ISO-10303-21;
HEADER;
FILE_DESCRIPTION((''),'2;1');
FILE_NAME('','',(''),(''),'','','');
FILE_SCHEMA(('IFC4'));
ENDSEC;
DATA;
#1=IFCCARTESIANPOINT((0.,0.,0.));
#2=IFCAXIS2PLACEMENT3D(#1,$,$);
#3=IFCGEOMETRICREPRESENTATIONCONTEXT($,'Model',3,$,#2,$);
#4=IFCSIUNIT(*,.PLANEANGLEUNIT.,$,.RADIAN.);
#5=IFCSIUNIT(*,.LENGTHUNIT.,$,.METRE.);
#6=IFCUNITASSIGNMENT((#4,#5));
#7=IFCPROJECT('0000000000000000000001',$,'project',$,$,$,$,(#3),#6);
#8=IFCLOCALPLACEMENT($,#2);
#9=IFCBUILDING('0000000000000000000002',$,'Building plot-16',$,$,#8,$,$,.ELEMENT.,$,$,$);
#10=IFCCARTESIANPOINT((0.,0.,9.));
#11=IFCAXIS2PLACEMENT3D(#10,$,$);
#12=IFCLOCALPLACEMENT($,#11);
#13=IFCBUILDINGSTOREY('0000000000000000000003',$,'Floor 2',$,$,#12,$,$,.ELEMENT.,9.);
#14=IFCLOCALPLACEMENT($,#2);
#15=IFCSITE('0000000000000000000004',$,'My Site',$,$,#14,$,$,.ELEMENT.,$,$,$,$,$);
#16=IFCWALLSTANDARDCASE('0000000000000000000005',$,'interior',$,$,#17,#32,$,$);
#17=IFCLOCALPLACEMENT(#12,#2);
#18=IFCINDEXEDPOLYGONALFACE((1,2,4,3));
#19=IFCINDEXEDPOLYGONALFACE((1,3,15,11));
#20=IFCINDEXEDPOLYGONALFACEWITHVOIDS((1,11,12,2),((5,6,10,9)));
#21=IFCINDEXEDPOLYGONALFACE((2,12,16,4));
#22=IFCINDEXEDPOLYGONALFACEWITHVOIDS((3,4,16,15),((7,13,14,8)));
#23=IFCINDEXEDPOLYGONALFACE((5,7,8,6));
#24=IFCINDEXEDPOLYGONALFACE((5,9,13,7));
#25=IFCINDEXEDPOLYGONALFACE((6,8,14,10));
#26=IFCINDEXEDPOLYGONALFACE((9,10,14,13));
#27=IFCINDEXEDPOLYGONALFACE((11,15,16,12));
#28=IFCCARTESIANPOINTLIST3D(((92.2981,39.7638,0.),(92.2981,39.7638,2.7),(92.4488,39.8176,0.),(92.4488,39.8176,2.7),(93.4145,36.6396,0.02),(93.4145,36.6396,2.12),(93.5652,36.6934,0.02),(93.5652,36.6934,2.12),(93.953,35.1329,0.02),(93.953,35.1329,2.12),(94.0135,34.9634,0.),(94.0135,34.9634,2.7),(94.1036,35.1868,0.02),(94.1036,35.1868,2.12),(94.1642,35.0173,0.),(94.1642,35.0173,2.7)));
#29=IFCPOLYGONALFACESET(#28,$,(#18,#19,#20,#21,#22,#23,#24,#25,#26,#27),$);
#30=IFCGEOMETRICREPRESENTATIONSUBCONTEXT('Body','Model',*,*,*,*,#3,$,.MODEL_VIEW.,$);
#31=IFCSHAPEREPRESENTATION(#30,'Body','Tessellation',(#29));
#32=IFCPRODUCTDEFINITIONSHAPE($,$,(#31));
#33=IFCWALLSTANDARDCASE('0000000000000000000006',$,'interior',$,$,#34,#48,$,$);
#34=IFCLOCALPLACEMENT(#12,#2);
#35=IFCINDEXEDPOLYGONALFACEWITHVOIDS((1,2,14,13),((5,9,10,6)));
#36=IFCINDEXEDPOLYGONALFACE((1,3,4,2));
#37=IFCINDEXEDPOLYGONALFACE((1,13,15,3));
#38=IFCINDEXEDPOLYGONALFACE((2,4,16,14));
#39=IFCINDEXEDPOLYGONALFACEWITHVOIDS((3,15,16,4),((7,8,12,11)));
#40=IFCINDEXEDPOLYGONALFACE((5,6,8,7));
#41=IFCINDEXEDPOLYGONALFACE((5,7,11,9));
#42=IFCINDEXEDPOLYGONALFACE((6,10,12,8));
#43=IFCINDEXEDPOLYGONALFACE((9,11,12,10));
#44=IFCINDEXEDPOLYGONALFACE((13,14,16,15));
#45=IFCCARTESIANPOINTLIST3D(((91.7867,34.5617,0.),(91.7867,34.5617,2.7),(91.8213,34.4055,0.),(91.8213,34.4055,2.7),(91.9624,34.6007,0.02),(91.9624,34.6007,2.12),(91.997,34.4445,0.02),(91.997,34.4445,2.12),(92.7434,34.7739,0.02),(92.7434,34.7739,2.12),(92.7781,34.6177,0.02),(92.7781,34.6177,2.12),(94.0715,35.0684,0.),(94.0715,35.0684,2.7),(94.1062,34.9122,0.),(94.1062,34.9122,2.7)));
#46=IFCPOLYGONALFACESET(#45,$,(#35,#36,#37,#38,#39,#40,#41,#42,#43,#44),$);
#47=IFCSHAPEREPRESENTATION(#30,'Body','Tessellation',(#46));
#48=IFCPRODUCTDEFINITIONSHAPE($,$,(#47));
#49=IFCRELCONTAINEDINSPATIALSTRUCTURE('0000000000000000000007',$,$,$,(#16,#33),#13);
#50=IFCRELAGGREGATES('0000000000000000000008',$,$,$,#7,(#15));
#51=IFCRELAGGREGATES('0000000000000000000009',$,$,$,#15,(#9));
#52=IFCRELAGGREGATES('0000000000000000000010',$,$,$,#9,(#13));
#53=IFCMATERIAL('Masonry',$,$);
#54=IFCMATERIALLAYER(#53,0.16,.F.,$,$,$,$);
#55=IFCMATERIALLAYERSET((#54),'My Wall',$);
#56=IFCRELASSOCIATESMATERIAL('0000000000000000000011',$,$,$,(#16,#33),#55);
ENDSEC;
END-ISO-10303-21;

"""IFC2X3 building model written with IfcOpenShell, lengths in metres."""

from ifc_helpers import new_model, si_unit, frame, origin, place, context, subcontext, project, spatial, polyline, outline, extrude, material, layer, layer_set, layer_usage, element, save


model = new_model("IFC2X3")

# Units and contexts
model_context = context("Model", 3, world=origin())
body_context = subcontext(model_context, "Body", "Model", "MODEL_VIEW")
ifc_project = project(units=[si_unit("PLANEANGLEUNIT", "RADIAN"), si_unit("LENGTHUNIT", "METRE")], contexts=[model_context])

# Site, building, storey
site_placement = place(None, origin())
site = spatial("IfcSite", under=ifc_project, at=site_placement, Name="My Site", CompositionType="ELEMENT")
building_placement = place(None, origin())
building = spatial("IfcBuilding", under=site, at=building_placement, Name="Building plot-16", CompositionType="ELEMENT")
storey_placement = place(None, frame((0.0, 0.0, 9.0)))
storey = spatial("IfcBuildingStorey", under=building, at=storey_placement, Name="Floor 2", CompositionType="ELEMENT", Elevation=9.0)

# Walls, openings
ifc_material = material(Name="Masonry")
ifc_layer = layer(ifc_material, 0.16, ventilated=False)
ifc_layer_set = layer_set([ifc_layer], Name="My Wall")
ifc_layer_usage = layer_usage(ifc_layer_set, "AXIS2", "NEGATIVE", 0.08)
wall_1_placement = place(storey_placement, origin())
wall_1 = element("IfcWallStandardCase", 1, at=wall_1_placement, inside=storey, material=ifc_layer_usage, Name="interior", context=body_context, shape_type="SweptSolid", body=[
    extrude(outline(polyline([(94.0135, 34.9634), (94.1642, 35.0173), (92.4488, 39.8176), (92.2981, 39.7638), (94.0135, 34.9634)])), origin(), (0.0, 0.0, 1.0), 2.7),
])
opening_1_placement = place(storey_placement, frame((0.0, 0.0, 0.02)))
element("IfcOpeningElement", 2, at=opening_1_placement, cuts=wall_1, ObjectType="Opening", context=body_context, shape_type="SweptSolid", body=[
    extrude(outline(polyline([(94.1036, 35.1868), (93.5652, 36.6934), (93.4145, 36.6396), (93.953, 35.1329), (94.1036, 35.1868)])), origin(), (0.0, 0.0, 1.0), 2.1),
])
wall_2_placement = place(storey_placement, origin())
wall_2 = element("IfcWallStandardCase", 3, at=wall_2_placement, inside=storey, material=ifc_layer_usage, Name="interior", context=body_context, shape_type="SweptSolid", body=[
    extrude(outline(polyline([(91.7867, 34.5617), (91.8213, 34.4055), (94.1062, 34.9122), (94.0715, 35.0684), (91.7867, 34.5617)])), origin(), (0.0, 0.0, 1.0), 2.7),
])
opening_2_placement = place(storey_placement, frame((0.0, 0.0, 0.02)))
element("IfcOpeningElement", 4, at=opening_2_placement, cuts=wall_2, ObjectType="Opening", context=body_context, shape_type="SweptSolid", body=[
    extrude(outline(polyline([(91.997, 34.4445), (92.7781, 34.6177), (92.7434, 34.7739), (91.9624, 34.6007), (91.997, 34.4445)])), origin(), (0.0, 0.0, 1.0), 2.1),
])

save(model, "model.ifc")
